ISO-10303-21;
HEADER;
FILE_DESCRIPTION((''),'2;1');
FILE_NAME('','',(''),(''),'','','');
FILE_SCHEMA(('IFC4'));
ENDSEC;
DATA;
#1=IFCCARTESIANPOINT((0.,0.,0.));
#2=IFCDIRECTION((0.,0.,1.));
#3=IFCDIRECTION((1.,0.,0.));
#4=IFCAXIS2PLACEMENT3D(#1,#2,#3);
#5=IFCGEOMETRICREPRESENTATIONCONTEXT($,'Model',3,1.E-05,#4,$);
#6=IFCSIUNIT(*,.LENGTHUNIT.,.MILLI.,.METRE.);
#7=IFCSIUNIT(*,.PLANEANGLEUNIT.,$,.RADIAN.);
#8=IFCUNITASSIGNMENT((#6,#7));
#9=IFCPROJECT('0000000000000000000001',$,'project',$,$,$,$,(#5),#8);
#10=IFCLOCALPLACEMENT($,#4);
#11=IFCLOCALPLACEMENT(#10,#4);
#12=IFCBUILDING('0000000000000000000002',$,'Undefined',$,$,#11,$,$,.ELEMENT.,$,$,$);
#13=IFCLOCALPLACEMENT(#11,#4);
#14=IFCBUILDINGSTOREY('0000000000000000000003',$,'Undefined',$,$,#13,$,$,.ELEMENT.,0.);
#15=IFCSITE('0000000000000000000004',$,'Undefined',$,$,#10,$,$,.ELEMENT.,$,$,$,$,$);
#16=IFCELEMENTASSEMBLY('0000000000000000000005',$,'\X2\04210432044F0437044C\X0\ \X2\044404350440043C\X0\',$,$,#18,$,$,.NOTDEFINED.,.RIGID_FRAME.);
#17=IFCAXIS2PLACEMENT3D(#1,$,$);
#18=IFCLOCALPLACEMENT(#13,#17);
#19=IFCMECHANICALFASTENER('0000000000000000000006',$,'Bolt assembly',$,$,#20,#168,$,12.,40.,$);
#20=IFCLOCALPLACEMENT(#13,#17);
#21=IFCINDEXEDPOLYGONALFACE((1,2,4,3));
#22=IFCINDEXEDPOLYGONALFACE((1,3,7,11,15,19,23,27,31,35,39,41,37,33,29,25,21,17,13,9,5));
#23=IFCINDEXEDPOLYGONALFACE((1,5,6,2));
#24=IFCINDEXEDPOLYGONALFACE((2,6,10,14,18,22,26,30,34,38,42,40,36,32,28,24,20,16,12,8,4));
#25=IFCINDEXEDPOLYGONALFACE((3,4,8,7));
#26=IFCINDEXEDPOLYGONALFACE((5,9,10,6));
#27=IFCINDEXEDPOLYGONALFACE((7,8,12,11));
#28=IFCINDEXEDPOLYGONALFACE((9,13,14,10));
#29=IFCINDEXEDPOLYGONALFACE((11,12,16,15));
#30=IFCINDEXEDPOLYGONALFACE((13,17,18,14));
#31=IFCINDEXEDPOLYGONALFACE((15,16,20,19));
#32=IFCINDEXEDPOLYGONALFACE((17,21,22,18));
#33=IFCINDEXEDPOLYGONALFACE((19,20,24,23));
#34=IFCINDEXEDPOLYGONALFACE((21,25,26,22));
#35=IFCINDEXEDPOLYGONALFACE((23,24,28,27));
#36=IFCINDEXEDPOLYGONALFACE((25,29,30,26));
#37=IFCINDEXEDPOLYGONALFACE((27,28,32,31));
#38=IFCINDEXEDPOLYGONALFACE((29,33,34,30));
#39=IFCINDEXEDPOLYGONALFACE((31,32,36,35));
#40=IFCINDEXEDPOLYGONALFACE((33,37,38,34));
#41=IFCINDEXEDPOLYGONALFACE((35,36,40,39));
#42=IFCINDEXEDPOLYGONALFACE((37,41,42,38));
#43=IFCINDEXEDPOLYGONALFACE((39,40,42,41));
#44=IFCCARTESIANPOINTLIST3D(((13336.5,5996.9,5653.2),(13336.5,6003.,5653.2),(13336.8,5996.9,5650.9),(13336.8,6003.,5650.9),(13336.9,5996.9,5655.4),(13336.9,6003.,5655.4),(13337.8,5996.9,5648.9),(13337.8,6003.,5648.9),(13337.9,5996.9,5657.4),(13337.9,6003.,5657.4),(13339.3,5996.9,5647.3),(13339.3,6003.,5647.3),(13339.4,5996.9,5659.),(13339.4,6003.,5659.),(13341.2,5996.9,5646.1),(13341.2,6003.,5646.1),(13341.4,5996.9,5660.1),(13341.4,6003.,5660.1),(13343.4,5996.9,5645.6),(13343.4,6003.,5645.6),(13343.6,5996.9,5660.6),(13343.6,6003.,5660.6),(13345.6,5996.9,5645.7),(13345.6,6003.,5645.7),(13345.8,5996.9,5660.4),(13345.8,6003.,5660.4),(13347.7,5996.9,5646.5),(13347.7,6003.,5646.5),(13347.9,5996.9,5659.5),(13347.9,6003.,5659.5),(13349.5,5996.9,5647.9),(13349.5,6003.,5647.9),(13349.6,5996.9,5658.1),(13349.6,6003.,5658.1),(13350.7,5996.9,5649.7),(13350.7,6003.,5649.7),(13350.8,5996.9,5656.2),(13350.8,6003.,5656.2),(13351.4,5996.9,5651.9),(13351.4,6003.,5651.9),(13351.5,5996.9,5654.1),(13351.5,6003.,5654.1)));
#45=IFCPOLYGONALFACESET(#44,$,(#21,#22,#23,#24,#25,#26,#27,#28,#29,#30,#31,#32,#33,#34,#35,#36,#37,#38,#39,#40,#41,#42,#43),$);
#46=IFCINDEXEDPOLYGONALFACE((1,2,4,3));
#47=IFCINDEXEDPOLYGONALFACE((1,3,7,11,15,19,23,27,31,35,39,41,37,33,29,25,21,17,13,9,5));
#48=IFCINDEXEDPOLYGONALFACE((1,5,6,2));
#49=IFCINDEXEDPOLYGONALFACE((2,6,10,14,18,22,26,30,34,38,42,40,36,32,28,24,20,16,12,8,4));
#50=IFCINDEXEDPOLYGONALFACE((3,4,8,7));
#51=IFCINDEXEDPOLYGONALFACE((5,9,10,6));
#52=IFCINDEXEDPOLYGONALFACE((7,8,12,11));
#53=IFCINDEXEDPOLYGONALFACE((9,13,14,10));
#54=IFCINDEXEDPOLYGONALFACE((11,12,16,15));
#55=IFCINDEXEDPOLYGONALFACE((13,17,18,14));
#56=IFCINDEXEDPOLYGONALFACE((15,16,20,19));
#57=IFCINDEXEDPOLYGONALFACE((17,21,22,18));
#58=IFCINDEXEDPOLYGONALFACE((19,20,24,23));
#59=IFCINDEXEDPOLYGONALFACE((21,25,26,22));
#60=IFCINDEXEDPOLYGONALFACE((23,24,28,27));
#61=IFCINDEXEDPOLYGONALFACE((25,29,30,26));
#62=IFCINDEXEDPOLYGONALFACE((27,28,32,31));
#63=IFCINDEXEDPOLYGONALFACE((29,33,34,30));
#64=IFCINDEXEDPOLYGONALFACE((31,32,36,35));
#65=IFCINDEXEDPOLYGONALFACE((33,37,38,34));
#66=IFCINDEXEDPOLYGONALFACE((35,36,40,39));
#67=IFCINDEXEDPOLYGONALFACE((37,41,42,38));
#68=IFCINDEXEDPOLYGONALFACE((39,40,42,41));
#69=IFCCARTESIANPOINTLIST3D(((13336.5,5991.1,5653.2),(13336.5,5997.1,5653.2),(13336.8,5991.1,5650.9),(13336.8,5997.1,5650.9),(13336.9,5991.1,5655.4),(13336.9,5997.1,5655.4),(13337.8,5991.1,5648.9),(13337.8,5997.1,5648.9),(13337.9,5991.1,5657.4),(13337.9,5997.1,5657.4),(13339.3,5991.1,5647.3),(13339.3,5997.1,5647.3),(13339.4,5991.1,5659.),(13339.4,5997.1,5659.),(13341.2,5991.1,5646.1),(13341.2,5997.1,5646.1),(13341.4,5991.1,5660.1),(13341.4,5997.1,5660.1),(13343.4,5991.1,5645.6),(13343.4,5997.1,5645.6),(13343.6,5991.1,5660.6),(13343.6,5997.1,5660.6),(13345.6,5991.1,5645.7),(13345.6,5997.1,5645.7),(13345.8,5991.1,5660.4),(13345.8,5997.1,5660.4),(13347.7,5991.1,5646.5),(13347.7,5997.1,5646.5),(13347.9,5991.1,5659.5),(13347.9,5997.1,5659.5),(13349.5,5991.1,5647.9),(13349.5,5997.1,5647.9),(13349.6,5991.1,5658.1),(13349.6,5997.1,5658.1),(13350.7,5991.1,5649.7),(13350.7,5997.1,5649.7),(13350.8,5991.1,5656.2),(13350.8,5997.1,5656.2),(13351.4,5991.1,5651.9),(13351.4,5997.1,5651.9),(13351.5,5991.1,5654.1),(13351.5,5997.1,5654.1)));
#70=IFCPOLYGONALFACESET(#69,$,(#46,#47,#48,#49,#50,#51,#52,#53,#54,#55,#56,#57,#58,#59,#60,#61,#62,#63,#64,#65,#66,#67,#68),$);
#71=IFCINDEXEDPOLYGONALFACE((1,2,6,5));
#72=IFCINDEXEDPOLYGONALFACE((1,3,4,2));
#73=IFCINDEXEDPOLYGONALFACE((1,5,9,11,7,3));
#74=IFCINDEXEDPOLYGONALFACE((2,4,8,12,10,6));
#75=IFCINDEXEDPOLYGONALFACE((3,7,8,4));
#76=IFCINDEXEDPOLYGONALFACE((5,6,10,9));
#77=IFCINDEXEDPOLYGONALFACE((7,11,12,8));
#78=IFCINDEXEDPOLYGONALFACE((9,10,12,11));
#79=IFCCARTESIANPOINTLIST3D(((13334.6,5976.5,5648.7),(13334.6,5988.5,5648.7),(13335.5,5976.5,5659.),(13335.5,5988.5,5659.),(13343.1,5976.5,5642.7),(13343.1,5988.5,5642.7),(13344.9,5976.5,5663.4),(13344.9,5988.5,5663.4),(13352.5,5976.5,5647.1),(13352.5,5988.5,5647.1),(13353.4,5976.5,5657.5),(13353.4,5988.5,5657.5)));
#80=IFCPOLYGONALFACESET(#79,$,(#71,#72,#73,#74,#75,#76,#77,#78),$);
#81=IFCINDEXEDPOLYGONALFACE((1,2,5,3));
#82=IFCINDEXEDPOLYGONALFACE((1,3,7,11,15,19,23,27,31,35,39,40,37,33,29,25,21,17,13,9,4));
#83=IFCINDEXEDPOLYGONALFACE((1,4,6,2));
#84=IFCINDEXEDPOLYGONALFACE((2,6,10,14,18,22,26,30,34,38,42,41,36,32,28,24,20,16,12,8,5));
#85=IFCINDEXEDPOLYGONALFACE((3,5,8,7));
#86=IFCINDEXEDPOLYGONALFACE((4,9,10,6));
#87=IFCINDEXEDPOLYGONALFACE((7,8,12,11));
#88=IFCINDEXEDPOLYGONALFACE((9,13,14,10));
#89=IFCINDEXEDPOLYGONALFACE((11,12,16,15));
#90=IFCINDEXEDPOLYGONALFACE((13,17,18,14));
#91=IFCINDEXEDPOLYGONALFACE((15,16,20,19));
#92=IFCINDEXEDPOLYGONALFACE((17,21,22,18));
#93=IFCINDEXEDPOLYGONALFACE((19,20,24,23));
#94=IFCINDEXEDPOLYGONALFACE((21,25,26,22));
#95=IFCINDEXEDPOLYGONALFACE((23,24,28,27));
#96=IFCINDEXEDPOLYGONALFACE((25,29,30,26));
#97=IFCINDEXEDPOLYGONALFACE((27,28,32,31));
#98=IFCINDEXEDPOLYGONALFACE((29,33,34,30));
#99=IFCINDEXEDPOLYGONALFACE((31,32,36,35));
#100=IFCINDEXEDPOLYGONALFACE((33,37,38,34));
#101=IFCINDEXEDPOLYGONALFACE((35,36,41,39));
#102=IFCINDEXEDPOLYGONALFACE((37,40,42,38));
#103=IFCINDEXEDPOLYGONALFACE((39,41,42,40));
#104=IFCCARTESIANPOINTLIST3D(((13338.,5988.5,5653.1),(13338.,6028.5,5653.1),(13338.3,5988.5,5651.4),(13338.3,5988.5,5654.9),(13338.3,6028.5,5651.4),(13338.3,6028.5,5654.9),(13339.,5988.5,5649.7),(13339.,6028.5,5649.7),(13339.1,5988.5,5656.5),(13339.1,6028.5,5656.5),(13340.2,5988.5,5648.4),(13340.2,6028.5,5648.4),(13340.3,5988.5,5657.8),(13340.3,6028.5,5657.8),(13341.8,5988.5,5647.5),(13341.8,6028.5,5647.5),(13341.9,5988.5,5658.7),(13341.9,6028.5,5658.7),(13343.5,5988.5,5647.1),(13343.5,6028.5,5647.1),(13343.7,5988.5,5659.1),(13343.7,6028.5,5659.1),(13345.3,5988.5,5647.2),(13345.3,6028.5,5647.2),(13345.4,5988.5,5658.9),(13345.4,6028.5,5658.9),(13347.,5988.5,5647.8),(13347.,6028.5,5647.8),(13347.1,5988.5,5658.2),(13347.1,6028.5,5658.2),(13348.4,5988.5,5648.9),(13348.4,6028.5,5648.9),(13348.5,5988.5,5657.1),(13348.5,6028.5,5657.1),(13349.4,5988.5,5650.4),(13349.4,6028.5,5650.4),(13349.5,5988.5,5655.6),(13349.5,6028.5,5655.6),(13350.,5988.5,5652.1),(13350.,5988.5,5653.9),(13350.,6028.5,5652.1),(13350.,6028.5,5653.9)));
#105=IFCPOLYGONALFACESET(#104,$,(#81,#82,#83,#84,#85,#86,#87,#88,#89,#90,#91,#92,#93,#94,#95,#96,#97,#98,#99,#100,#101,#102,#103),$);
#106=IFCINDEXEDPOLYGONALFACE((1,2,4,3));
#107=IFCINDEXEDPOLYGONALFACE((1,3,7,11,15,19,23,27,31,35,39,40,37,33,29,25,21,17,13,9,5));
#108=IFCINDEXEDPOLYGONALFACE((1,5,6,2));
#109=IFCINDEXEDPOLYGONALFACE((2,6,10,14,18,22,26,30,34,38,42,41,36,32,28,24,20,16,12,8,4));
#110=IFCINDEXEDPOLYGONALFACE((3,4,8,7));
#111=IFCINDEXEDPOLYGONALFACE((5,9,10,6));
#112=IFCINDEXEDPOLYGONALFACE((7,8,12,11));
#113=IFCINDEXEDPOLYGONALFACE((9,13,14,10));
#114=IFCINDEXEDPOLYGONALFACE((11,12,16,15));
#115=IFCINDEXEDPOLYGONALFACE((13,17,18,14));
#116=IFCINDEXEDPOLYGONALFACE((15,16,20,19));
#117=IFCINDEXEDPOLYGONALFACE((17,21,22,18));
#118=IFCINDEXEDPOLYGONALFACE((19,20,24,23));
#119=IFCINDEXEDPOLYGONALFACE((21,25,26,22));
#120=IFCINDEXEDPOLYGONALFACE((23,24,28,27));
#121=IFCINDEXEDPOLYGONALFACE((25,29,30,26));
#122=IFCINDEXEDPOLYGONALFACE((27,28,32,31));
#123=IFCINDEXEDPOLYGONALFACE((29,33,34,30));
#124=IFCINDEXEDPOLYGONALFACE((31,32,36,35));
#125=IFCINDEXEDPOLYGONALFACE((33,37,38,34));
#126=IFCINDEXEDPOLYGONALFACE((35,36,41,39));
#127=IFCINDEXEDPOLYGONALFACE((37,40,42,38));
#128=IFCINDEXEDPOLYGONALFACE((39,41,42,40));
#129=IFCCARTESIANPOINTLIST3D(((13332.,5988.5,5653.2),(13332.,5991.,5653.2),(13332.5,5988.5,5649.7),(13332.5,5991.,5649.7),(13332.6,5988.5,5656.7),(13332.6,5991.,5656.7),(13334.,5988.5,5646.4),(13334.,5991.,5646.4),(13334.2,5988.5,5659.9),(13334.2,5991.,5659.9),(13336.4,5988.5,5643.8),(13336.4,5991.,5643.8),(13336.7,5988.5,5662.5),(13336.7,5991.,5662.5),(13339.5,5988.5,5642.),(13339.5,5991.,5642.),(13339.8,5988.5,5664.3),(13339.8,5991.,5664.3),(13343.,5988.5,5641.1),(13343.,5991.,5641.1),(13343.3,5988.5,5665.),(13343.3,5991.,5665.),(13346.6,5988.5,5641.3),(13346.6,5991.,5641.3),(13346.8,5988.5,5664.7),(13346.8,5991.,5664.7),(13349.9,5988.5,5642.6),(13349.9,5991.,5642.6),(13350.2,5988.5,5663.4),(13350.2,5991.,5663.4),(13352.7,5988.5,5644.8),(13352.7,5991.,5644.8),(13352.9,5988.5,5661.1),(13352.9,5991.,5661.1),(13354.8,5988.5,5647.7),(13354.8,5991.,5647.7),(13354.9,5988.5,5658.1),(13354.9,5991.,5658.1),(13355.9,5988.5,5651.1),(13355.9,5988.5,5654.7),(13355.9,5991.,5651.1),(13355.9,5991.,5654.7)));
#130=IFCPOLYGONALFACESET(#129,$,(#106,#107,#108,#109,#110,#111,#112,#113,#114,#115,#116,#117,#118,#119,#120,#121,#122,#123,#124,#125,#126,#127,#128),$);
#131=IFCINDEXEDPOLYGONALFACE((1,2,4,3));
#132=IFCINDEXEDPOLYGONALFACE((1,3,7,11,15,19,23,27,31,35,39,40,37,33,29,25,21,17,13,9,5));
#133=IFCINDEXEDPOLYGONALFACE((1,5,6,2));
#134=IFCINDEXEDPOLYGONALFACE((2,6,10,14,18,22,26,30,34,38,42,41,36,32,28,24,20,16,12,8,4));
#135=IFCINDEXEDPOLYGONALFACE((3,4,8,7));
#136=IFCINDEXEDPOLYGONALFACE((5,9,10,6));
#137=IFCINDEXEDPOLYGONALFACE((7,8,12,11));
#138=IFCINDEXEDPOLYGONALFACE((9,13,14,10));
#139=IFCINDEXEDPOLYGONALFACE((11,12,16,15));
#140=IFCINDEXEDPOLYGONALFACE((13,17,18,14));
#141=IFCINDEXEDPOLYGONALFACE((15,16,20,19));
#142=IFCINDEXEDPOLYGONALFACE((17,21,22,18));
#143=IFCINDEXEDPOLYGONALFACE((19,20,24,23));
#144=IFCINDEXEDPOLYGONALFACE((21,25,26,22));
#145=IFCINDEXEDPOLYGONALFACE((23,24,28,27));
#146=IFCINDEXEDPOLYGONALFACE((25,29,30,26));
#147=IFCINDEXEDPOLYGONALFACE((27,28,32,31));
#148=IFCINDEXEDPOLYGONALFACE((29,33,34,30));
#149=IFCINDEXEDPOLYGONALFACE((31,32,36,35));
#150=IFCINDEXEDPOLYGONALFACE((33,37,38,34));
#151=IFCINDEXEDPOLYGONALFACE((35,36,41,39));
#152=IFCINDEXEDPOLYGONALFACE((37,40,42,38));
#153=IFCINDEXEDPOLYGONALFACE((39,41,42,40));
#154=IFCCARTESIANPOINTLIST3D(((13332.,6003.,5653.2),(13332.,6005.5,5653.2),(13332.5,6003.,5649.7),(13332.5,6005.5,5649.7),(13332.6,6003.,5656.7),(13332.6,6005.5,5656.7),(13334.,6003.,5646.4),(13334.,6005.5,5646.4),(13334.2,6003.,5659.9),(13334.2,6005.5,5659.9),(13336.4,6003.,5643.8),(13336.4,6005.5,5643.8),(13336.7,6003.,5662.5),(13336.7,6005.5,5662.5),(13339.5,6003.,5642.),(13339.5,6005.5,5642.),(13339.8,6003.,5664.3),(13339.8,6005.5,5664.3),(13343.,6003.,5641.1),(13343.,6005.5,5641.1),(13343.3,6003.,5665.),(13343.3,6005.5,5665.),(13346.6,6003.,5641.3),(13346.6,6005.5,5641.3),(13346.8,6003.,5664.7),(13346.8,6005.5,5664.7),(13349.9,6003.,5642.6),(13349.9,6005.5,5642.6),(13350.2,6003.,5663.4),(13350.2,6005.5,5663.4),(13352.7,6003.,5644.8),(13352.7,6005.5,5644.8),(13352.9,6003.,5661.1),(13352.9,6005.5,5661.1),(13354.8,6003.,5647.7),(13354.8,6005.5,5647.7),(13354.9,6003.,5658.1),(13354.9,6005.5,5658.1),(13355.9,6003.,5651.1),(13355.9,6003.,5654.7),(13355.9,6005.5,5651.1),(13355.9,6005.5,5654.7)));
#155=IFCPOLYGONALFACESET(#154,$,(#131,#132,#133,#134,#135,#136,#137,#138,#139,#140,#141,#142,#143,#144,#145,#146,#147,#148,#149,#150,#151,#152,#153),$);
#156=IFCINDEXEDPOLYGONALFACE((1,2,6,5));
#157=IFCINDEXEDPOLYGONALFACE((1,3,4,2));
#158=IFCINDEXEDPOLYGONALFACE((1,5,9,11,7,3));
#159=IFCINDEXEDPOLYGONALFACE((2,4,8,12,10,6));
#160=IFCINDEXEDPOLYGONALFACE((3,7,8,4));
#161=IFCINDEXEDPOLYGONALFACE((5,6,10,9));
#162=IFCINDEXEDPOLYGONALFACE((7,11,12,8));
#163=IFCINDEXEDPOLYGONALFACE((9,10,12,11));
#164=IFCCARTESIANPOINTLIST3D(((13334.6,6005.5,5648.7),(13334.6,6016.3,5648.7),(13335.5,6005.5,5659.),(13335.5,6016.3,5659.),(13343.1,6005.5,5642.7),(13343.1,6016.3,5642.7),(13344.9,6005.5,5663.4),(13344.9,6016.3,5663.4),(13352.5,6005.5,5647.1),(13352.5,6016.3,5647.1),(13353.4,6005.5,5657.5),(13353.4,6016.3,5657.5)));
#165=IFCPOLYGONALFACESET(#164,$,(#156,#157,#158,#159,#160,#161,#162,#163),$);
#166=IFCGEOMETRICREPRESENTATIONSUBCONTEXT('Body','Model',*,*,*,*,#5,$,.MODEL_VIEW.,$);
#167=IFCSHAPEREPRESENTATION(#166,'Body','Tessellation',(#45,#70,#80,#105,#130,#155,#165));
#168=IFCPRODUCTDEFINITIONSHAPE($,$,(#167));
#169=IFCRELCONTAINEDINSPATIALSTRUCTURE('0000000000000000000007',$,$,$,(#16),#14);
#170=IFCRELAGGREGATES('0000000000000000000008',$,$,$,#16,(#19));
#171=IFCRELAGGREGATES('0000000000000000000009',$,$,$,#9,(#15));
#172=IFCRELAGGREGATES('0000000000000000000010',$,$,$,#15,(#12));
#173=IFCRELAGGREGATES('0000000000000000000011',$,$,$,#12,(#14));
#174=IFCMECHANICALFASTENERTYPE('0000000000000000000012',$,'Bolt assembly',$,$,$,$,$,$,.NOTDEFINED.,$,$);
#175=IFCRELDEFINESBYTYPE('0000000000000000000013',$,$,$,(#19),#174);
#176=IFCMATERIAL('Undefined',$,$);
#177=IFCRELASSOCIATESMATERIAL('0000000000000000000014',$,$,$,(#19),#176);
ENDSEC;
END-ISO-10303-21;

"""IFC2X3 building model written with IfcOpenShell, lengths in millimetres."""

from ifc_helpers import new_model, si_unit, frame, origin_with_axes, origin_2d_with_axis, place, context, subcontext, project, spatial, polyline, circle, outline, extrude, source, transform, mapped, material, type_object, element, aggregate, save


model = new_model("IFC2X3")

# Units and contexts
model_context = context("Model", 3, precision=1e-05, world=origin_with_axes())
body_context = subcontext(model_context, "Body", "Model", "MODEL_VIEW")
ifc_project = project(units=[si_unit("LENGTHUNIT", "METRE", prefix="MILLI"), si_unit("PLANEANGLEUNIT", "RADIAN")], contexts=[model_context])

# Site, building, storey
site_placement = place(None, origin_with_axes())
site = spatial("IfcSite", under=ifc_project, at=site_placement, Name="Undefined", CompositionType="ELEMENT")
building_placement = place(site_placement, origin_with_axes())
building = spatial("IfcBuilding", under=site, at=building_placement, Name="Undefined", CompositionType="ELEMENT")
storey_placement = place(building_placement, origin_with_axes())
storey = spatial("IfcBuildingStorey", under=building, at=storey_placement, Name="Undefined", CompositionType="ELEMENT", Elevation=0.0)

# Element assembly
assembly_1_placement = place(storey_placement, origin_with_axes())
assembly_1 = element("IfcElementAssembly", 1, at=assembly_1_placement, inside=storey, Name="Связь ферм", AssemblyPlace="NOTDEFINED", PredefinedType="RIGID_FRAME")

# Mechanical fastener
ifc_material_1 = material(Name="Undefined")
mechanical_fastener_type = type_object("IfcMechanicalFastenerType", Name="Bolt assembly")
shared_shape_1 = source(origin_with_axes(), body_context, "Body", "SweptSolid", [
    extrude(circle(Radius=7.5, at=origin_2d_with_axis()), frame((0.0, -0.1, 0.0), z_axis=(0.0, 1.0, 0.0), x_axis=(1.0, 0.0, 0.0)), (0.0, 0.0, 1.0), 6.1),
    extrude(circle(Radius=7.5, at=origin_2d_with_axis()), frame((0.0, -5.9, 0.0), z_axis=(0.0, 1.0, 0.0), x_axis=(1.0, 0.0, 0.0)), (0.0, 0.0, 1.0), 6.0),
    extrude(outline(polyline([(10.4, 0.0), (5.2, 9.0), (-5.2, 9.0), (-10.4, 0.0), (-5.2, -9.0), (5.2, -9.0), (10.4, 0.0)])), frame((0.0, -20.5, 0.0), z_axis=(0.0, 1.0, 0.0), x_axis=(1.0, 0.0, 0.0)), (0.0, 0.0, 1.0), 12.0),
    extrude(circle(Radius=6.0, at=origin_2d_with_axis()), frame((0.0, -8.5, 0.0), z_axis=(0.0, 1.0, 0.0), x_axis=(1.0, 0.0, 0.0)), (0.0, 0.0, 1.0), 40.0),
    extrude(circle(Radius=12.0, at=origin_2d_with_axis()), frame((0.0, -8.5, 0.0), z_axis=(0.0, 1.0, 0.0), x_axis=(1.0, 0.0, 0.0)), (0.0, 0.0, 1.0), 2.5),
    extrude(circle(Radius=12.0, at=origin_2d_with_axis()), frame((0.0, 6.0, 0.0), z_axis=(0.0, 1.0, 0.0), x_axis=(1.0, 0.0, 0.0)), (0.0, 0.0, 1.0), 2.5),
    extrude(outline(polyline([(10.4, 0.0), (5.2, 9.0), (-5.2, 9.0), (-10.4, 0.0), (-5.2, -9.0), (5.2, -9.0), (10.4, 0.0)])), frame((0.0, 8.5, 0.0), z_axis=(0.0, 1.0, 0.0), x_axis=(1.0, 0.0, 0.0)), (0.0, 0.0, 1.0), 10.8),
])
mechanical_fastener_1_placement = place(assembly_1_placement, frame((13344.0, 5997.0, 5653.1), z_axis=(-0.573078, 0.0, -0.819501), x_axis=(-0.819501, 0.0, 0.573078)))
mechanical_fastener_1 = element("IfcMechanicalFastener", 2, at=mechanical_fastener_1_placement, type_object=mechanical_fastener_type, material=ifc_material_1, Name="Bolt assembly", NominalDiameter=12.0, NominalLength=40.0, context=body_context, shape_type="MappedRepresentation", body=[
    mapped(shared_shape_1, transform((0.0, 0.0, 0.0))),
])
aggregate(assembly_1, [mechanical_fastener_1])

save(model, "model.ifc")
